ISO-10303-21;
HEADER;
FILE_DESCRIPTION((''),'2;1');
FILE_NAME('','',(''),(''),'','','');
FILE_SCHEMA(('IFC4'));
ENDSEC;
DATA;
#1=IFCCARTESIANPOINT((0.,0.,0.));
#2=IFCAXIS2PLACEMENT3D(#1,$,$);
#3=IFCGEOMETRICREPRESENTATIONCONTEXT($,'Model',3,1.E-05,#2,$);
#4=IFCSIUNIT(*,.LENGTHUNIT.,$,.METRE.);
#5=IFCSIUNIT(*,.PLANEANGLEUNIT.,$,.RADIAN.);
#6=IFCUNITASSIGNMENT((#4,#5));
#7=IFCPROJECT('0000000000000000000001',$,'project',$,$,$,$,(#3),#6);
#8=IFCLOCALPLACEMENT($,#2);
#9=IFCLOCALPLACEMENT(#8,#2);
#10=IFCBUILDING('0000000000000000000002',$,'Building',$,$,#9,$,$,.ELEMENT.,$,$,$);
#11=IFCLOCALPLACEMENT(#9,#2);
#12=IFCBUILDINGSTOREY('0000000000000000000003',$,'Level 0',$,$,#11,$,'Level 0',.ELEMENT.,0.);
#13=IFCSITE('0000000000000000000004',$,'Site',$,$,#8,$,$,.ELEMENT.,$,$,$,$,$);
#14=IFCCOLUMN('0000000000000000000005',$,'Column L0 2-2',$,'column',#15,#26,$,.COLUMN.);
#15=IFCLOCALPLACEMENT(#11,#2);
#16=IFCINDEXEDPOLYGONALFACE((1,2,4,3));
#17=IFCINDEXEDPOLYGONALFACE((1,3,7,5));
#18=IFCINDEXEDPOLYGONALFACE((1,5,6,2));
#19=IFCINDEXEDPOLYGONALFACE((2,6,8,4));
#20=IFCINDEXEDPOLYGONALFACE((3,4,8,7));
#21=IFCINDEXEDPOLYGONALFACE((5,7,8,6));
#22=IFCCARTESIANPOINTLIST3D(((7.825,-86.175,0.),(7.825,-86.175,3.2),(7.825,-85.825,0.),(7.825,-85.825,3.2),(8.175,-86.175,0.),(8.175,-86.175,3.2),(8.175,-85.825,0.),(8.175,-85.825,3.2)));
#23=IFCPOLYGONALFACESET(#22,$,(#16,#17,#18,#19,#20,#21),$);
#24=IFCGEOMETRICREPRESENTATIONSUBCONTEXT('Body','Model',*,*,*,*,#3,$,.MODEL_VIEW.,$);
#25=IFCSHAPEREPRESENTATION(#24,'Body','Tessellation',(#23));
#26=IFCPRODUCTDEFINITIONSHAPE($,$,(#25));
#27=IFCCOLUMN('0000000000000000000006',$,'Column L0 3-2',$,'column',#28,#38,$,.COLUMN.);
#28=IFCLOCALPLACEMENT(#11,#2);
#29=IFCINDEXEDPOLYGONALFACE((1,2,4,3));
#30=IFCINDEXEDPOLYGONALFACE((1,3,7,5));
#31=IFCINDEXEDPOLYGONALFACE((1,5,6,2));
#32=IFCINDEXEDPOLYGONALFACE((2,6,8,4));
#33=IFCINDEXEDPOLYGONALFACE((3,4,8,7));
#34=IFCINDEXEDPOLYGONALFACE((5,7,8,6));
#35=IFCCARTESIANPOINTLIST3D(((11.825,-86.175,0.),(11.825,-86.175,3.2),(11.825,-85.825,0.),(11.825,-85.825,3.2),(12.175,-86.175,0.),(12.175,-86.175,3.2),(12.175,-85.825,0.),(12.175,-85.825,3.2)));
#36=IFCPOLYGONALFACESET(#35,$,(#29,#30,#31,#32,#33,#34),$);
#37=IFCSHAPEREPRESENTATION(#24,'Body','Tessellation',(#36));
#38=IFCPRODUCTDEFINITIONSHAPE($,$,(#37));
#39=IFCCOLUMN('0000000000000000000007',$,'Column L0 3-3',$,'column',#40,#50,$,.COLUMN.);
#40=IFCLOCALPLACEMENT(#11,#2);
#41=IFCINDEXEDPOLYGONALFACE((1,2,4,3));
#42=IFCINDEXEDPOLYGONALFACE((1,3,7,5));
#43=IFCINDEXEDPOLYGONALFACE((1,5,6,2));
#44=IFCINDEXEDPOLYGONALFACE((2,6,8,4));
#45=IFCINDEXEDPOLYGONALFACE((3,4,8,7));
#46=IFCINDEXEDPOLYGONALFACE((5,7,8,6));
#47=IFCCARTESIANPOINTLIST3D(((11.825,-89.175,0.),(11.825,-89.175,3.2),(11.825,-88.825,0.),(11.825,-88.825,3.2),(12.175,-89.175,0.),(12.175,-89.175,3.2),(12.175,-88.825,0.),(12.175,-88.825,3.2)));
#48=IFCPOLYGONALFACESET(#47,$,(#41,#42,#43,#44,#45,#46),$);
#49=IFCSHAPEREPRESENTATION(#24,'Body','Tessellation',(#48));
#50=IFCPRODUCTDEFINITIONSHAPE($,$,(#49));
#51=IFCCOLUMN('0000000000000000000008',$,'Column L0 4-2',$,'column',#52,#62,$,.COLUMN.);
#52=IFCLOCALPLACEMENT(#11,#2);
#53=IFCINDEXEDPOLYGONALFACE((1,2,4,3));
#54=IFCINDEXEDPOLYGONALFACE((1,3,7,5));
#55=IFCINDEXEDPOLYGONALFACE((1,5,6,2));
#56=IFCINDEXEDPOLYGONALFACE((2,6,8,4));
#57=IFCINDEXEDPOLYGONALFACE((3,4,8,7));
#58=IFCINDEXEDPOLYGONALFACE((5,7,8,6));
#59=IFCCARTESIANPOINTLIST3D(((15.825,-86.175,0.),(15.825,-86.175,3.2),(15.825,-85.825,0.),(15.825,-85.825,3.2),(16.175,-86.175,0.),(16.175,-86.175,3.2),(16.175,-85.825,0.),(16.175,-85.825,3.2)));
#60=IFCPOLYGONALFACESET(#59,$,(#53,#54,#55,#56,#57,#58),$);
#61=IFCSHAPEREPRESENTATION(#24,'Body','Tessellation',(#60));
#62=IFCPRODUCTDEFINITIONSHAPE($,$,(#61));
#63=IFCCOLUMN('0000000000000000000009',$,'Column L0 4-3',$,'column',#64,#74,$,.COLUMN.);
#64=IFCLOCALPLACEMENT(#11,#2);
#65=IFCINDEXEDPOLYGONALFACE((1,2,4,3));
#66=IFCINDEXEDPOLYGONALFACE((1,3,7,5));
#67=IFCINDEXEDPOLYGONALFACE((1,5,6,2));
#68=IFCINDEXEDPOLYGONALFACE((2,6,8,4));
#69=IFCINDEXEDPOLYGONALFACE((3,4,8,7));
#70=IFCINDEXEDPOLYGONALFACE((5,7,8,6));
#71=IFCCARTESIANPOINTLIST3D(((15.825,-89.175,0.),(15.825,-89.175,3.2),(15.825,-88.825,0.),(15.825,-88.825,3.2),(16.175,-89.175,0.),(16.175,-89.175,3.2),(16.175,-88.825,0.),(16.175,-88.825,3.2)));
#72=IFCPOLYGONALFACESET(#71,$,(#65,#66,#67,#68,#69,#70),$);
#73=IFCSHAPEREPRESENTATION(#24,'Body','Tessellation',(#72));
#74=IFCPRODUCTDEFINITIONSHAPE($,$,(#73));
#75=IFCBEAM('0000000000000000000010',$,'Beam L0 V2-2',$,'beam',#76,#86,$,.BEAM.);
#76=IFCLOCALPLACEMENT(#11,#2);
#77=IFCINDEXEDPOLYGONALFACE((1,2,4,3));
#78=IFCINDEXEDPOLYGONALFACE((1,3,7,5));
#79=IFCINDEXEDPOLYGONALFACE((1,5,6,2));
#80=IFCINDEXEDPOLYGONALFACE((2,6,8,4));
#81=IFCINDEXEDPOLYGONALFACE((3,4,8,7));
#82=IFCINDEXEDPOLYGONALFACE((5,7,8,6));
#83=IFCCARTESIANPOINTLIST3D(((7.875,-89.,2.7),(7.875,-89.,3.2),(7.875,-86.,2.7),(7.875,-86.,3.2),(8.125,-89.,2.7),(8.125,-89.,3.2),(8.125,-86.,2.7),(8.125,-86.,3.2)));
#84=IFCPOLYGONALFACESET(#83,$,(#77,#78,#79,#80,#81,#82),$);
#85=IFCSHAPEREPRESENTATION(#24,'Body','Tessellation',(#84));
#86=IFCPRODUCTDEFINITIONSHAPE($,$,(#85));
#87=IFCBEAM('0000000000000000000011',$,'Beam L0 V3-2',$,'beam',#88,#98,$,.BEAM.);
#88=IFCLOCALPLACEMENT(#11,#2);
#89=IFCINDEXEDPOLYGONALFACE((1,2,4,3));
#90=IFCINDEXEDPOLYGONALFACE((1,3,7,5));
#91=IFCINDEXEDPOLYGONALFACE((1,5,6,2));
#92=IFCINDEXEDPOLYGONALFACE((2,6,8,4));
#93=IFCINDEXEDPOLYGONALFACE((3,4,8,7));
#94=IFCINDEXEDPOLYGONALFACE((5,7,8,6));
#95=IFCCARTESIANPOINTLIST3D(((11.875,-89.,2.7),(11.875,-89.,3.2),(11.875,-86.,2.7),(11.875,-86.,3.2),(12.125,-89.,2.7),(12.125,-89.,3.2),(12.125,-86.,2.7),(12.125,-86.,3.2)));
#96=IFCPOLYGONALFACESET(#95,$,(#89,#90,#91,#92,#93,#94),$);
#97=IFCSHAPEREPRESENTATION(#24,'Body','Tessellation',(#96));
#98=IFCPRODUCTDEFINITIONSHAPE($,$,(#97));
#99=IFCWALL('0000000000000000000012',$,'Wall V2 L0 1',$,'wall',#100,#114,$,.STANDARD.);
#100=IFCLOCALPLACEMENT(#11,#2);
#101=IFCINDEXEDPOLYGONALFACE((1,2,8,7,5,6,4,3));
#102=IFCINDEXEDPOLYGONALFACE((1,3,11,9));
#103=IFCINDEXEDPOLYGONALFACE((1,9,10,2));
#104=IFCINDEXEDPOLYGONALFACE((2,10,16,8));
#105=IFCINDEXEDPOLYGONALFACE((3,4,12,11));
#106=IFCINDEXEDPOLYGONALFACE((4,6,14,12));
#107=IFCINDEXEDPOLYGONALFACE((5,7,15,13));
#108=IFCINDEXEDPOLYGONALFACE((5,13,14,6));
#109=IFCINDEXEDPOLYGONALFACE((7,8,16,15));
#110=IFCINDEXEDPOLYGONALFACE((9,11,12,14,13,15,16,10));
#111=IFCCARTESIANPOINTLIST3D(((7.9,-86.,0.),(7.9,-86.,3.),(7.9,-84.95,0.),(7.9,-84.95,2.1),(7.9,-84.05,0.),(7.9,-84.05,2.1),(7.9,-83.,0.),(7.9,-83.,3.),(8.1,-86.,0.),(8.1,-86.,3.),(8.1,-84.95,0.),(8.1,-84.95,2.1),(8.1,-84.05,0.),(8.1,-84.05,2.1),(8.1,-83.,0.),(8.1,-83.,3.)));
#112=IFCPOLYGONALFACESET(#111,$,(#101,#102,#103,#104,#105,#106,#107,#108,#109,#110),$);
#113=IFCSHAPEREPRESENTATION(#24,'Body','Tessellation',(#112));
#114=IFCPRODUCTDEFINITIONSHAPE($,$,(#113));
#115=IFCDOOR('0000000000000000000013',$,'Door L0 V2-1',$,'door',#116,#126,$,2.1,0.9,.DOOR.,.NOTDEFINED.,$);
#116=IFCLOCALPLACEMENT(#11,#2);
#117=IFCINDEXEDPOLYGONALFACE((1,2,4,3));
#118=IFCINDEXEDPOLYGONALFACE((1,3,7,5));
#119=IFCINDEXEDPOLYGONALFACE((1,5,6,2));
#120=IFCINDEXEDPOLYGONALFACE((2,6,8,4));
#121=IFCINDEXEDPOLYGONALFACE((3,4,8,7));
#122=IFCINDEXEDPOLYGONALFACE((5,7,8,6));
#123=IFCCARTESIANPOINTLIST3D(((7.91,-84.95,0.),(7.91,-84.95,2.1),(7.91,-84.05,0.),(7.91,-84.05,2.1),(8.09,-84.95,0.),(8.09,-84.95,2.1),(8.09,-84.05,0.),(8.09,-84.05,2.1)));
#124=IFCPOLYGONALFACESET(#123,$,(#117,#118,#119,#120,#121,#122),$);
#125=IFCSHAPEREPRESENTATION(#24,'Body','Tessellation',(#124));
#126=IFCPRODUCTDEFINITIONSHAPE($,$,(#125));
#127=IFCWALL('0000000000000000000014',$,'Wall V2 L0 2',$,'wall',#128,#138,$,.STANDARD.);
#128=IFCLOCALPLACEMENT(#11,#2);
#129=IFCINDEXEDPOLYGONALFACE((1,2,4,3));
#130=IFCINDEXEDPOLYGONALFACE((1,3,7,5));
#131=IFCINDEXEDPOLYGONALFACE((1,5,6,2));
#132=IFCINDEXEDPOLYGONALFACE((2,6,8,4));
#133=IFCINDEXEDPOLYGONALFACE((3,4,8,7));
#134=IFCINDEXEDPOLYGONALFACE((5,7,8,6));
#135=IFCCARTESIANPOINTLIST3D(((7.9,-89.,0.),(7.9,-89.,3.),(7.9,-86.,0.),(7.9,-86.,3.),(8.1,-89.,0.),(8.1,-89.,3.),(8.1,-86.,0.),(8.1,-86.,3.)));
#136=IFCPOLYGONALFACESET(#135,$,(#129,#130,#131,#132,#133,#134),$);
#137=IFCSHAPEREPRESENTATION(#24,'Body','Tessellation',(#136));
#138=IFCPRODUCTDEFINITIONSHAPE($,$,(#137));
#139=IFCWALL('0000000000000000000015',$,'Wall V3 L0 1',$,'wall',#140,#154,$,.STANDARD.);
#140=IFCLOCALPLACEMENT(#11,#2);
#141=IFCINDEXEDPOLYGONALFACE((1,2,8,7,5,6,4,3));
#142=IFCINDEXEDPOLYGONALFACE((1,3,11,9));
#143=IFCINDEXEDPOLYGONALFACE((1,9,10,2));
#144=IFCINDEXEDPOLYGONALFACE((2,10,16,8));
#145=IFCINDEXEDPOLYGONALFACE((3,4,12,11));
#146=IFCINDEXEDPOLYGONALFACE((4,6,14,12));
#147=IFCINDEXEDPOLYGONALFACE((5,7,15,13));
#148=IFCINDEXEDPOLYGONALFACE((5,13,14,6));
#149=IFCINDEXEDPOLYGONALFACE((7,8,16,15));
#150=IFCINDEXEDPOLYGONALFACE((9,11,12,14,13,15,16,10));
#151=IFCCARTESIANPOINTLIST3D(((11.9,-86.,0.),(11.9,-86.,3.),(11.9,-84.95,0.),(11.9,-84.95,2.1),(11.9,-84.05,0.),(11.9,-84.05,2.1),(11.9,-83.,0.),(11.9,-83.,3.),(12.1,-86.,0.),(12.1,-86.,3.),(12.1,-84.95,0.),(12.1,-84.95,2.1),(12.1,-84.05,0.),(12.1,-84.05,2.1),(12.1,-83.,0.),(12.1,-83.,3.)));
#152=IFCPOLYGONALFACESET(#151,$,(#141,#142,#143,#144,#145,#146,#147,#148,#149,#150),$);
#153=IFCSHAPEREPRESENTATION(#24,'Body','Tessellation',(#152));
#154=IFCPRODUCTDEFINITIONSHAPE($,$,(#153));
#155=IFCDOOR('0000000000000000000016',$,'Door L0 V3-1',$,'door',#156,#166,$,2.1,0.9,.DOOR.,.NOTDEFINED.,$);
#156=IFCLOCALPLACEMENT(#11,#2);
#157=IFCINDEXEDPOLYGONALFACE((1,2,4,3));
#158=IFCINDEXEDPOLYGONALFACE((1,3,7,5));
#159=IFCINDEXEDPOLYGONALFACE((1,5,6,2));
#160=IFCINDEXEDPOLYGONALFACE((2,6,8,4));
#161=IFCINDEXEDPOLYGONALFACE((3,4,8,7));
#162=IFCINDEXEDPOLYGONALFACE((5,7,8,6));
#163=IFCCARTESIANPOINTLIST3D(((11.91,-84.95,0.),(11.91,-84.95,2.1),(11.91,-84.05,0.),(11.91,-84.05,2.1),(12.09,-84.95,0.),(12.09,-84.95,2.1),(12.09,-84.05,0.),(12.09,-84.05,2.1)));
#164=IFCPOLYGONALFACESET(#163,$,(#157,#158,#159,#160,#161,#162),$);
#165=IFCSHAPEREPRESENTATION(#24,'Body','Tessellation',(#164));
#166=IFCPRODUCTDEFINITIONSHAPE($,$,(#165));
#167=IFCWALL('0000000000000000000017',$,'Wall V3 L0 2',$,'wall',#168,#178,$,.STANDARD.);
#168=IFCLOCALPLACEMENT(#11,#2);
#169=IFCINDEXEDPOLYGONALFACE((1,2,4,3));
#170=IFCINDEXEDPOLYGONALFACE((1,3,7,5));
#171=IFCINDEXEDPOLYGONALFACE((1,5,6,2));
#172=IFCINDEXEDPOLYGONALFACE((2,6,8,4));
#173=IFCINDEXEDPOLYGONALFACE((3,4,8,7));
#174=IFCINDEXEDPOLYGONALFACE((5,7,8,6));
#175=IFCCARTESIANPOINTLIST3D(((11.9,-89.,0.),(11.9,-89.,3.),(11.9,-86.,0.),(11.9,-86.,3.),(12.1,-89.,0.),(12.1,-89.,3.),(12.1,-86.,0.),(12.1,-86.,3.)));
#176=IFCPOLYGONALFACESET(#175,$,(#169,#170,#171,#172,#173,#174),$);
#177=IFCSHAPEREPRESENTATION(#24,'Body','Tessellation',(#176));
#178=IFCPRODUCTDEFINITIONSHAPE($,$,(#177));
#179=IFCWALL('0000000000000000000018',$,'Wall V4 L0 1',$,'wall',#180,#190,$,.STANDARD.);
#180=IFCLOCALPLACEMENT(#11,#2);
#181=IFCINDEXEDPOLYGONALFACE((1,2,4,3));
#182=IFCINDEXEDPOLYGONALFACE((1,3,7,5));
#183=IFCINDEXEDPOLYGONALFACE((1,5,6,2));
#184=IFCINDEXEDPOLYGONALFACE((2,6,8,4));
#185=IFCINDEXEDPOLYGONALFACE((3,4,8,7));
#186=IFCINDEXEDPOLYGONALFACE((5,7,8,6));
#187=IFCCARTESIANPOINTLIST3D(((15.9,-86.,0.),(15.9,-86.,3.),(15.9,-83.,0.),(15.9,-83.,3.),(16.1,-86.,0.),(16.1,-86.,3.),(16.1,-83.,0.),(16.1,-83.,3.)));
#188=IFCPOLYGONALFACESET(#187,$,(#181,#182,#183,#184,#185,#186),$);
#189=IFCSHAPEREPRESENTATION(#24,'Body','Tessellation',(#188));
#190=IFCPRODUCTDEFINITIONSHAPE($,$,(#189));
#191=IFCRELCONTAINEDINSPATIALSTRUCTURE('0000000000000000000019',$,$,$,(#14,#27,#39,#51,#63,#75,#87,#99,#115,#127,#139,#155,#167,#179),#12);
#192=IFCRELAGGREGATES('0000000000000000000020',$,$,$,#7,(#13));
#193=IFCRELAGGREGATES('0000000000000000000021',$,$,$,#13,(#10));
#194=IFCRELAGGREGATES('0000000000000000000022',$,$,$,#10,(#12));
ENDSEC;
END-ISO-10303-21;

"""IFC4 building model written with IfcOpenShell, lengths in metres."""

from ifc_helpers import new_model, si_unit, frame, frame_2d, origin, origin_2d, place, context, subcontext, project, spatial, rectangle, extrude, element, fill, save


model = new_model("IFC4")

# Units and contexts
model_context = context("Model", 3, precision=1e-05, world=origin())
body_context = subcontext(model_context, "Body", "Model", "MODEL_VIEW")
ifc_project = project(units=[si_unit("LENGTHUNIT", "METRE"), si_unit("PLANEANGLEUNIT", "RADIAN")], contexts=[model_context])

# Site, building, storey
site_placement = place(None, origin())
site = spatial("IfcSite", under=ifc_project, at=site_placement, Name="Site", CompositionType="ELEMENT")
building_placement = place(site_placement, origin())
building = spatial("IfcBuilding", under=site, at=building_placement, Name="Building", CompositionType="ELEMENT")
storey_placement = place(building_placement, origin())
storey = spatial("IfcBuildingStorey", under=building, at=storey_placement, Name="Level 0", LongName="Level 0", CompositionType="ELEMENT", Elevation=0.0)

# Columns
for number, where, name in (
    (1, (8.0, -86.0, 0.0), "Column L0 2-2"),
    (2, (12.0, -86.0, 0.0), "Column L0 3-2"),
    (3, (12.0, -89.0, 0.0), "Column L0 3-3"),
    (4, (16.0, -86.0, 0.0), "Column L0 4-2"),
    (5, (16.0, -89.0, 0.0), "Column L0 4-3"),
):
    element("IfcColumn", number, at=place(storey_placement, frame(where)), inside=storey, Name=name, ObjectType="column", PredefinedType="COLUMN", context=body_context, shape_type="SweptSolid", body=[
        extrude(rectangle(XDim=0.35, YDim=0.35, at=origin_2d()), origin(), (0.0, 0.0, 1.0), 3.2),
    ])

# Beams
for number, where, z_axis, x_axis, name in (
    (6, (8.0, -86.0, 2.95), (0.0, -1.0, 0.0), (0.0, 0.0, 1.0), "Beam L0 V2-2"),
    (7, (12.0, -86.0, 2.95), (0.0, -1.0, 0.0), (0.0, 0.0, 1.0), "Beam L0 V3-2"),
):
    element("IfcBeam", number, at=place(storey_placement, frame(where, z_axis=z_axis, x_axis=x_axis)), inside=storey, Name=name, ObjectType="beam", PredefinedType="BEAM", context=body_context, shape_type="SweptSolid", body=[
        extrude(rectangle(XDim=0.5, YDim=0.25, at=origin_2d()), origin(), (0.0, 0.0, 1.0), 3.0),
    ])

# Wall, opening, door
wall_1_placement = place(storey_placement, frame((8.0, -83.0, 0.0), z_axis=(0.0, 0.0, 1.0), x_axis=(0.0, -1.0, 0.0)))
wall_1 = element("IfcWall", 8, at=wall_1_placement, inside=storey, Name="Wall V2 L0 1", ObjectType="wall", PredefinedType="STANDARD", context=body_context, shape_type="SweptSolid", body=[
    extrude(rectangle(XDim=3.0, YDim=0.2, at=frame_2d((1.5, 0.0))), origin(), (0.0, 0.0, 1.0), 3.0),
])
opening_1_placement = place(storey_placement, frame((8.0, -84.5, 0.0), z_axis=(0.0, 0.0, 1.0), x_axis=(0.0, -1.0, 0.0)))
opening_1 = element("IfcOpeningElement", 9, at=opening_1_placement, cuts=wall_1, ObjectType="Opening", PredefinedType="OPENING", context=body_context, shape_type="SweptSolid", body=[
    extrude(rectangle(XDim=0.9, YDim=0.22, at=origin_2d()), origin(), (0.0, 0.0, 1.0), 2.1),
])
door_1_placement = place(storey_placement, frame((8.0, -84.5, 0.0), z_axis=(0.0, 0.0, 1.0), x_axis=(0.0, -1.0, 0.0)))
door_1 = element("IfcDoor", 10, at=door_1_placement, inside=storey, Name="Door L0 V2-1", ObjectType="door", OperationType="NOTDEFINED", OverallHeight=2.1, OverallWidth=0.9, PredefinedType="DOOR", context=body_context, shape_type="SweptSolid", body=[
    extrude(rectangle(XDim=0.9, YDim=0.18, at=origin_2d()), origin(), (0.0, 0.0, 1.0), 2.1),
])
fill(opening_1, door_1)

# Wall
wall_2_placement = place(storey_placement, frame((8.0, -86.0, 0.0), z_axis=(0.0, 0.0, 1.0), x_axis=(0.0, -1.0, 0.0)))
element("IfcWall", 11, at=wall_2_placement, inside=storey, Name="Wall V2 L0 2", ObjectType="wall", PredefinedType="STANDARD", context=body_context, shape_type="SweptSolid", body=[
    extrude(rectangle(XDim=3.0, YDim=0.2, at=frame_2d((1.5, 0.0))), origin(), (0.0, 0.0, 1.0), 3.0),
])

# Wall, opening, door
wall_3_placement = place(storey_placement, frame((12.0, -83.0, 0.0), z_axis=(0.0, 0.0, 1.0), x_axis=(0.0, -1.0, 0.0)))
wall_3 = element("IfcWall", 12, at=wall_3_placement, inside=storey, Name="Wall V3 L0 1", ObjectType="wall", PredefinedType="STANDARD", context=body_context, shape_type="SweptSolid", body=[
    extrude(rectangle(XDim=3.0, YDim=0.2, at=frame_2d((1.5, 0.0))), origin(), (0.0, 0.0, 1.0), 3.0),
])
opening_2_placement = place(storey_placement, frame((12.0, -84.5, 0.0), z_axis=(0.0, 0.0, 1.0), x_axis=(0.0, -1.0, 0.0)))
opening_2 = element("IfcOpeningElement", 13, at=opening_2_placement, cuts=wall_3, ObjectType="Opening", PredefinedType="OPENING", context=body_context, shape_type="SweptSolid", body=[
    extrude(rectangle(XDim=0.9, YDim=0.22, at=origin_2d()), origin(), (0.0, 0.0, 1.0), 2.1),
])
door_2_placement = place(storey_placement, frame((12.0, -84.5, 0.0), z_axis=(0.0, 0.0, 1.0), x_axis=(0.0, -1.0, 0.0)))
door_2 = element("IfcDoor", 14, at=door_2_placement, inside=storey, Name="Door L0 V3-1", ObjectType="door", OperationType="NOTDEFINED", OverallHeight=2.1, OverallWidth=0.9, PredefinedType="DOOR", context=body_context, shape_type="SweptSolid", body=[
    extrude(rectangle(XDim=0.9, YDim=0.18, at=origin_2d()), origin(), (0.0, 0.0, 1.0), 2.1),
])
fill(opening_2, door_2)

# Walls
for number, where, z_axis, x_axis, name in (
    (15, (12.0, -86.0, 0.0), (0.0, 0.0, 1.0), (0.0, -1.0, 0.0), "Wall V3 L0 2"),
    (16, (16.0, -83.0, 0.0), (0.0, 0.0, 1.0), (0.0, -1.0, 0.0), "Wall V4 L0 1"),
):
    element("IfcWall", number, at=place(storey_placement, frame(where, z_axis=z_axis, x_axis=x_axis)), inside=storey, Name=name, ObjectType="wall", PredefinedType="STANDARD", context=body_context, shape_type="SweptSolid", body=[
        extrude(rectangle(XDim=3.0, YDim=0.2, at=frame_2d((1.5, 0.0))), origin(), (0.0, 0.0, 1.0), 3.0),
    ])

save(model, "model.ifc")
